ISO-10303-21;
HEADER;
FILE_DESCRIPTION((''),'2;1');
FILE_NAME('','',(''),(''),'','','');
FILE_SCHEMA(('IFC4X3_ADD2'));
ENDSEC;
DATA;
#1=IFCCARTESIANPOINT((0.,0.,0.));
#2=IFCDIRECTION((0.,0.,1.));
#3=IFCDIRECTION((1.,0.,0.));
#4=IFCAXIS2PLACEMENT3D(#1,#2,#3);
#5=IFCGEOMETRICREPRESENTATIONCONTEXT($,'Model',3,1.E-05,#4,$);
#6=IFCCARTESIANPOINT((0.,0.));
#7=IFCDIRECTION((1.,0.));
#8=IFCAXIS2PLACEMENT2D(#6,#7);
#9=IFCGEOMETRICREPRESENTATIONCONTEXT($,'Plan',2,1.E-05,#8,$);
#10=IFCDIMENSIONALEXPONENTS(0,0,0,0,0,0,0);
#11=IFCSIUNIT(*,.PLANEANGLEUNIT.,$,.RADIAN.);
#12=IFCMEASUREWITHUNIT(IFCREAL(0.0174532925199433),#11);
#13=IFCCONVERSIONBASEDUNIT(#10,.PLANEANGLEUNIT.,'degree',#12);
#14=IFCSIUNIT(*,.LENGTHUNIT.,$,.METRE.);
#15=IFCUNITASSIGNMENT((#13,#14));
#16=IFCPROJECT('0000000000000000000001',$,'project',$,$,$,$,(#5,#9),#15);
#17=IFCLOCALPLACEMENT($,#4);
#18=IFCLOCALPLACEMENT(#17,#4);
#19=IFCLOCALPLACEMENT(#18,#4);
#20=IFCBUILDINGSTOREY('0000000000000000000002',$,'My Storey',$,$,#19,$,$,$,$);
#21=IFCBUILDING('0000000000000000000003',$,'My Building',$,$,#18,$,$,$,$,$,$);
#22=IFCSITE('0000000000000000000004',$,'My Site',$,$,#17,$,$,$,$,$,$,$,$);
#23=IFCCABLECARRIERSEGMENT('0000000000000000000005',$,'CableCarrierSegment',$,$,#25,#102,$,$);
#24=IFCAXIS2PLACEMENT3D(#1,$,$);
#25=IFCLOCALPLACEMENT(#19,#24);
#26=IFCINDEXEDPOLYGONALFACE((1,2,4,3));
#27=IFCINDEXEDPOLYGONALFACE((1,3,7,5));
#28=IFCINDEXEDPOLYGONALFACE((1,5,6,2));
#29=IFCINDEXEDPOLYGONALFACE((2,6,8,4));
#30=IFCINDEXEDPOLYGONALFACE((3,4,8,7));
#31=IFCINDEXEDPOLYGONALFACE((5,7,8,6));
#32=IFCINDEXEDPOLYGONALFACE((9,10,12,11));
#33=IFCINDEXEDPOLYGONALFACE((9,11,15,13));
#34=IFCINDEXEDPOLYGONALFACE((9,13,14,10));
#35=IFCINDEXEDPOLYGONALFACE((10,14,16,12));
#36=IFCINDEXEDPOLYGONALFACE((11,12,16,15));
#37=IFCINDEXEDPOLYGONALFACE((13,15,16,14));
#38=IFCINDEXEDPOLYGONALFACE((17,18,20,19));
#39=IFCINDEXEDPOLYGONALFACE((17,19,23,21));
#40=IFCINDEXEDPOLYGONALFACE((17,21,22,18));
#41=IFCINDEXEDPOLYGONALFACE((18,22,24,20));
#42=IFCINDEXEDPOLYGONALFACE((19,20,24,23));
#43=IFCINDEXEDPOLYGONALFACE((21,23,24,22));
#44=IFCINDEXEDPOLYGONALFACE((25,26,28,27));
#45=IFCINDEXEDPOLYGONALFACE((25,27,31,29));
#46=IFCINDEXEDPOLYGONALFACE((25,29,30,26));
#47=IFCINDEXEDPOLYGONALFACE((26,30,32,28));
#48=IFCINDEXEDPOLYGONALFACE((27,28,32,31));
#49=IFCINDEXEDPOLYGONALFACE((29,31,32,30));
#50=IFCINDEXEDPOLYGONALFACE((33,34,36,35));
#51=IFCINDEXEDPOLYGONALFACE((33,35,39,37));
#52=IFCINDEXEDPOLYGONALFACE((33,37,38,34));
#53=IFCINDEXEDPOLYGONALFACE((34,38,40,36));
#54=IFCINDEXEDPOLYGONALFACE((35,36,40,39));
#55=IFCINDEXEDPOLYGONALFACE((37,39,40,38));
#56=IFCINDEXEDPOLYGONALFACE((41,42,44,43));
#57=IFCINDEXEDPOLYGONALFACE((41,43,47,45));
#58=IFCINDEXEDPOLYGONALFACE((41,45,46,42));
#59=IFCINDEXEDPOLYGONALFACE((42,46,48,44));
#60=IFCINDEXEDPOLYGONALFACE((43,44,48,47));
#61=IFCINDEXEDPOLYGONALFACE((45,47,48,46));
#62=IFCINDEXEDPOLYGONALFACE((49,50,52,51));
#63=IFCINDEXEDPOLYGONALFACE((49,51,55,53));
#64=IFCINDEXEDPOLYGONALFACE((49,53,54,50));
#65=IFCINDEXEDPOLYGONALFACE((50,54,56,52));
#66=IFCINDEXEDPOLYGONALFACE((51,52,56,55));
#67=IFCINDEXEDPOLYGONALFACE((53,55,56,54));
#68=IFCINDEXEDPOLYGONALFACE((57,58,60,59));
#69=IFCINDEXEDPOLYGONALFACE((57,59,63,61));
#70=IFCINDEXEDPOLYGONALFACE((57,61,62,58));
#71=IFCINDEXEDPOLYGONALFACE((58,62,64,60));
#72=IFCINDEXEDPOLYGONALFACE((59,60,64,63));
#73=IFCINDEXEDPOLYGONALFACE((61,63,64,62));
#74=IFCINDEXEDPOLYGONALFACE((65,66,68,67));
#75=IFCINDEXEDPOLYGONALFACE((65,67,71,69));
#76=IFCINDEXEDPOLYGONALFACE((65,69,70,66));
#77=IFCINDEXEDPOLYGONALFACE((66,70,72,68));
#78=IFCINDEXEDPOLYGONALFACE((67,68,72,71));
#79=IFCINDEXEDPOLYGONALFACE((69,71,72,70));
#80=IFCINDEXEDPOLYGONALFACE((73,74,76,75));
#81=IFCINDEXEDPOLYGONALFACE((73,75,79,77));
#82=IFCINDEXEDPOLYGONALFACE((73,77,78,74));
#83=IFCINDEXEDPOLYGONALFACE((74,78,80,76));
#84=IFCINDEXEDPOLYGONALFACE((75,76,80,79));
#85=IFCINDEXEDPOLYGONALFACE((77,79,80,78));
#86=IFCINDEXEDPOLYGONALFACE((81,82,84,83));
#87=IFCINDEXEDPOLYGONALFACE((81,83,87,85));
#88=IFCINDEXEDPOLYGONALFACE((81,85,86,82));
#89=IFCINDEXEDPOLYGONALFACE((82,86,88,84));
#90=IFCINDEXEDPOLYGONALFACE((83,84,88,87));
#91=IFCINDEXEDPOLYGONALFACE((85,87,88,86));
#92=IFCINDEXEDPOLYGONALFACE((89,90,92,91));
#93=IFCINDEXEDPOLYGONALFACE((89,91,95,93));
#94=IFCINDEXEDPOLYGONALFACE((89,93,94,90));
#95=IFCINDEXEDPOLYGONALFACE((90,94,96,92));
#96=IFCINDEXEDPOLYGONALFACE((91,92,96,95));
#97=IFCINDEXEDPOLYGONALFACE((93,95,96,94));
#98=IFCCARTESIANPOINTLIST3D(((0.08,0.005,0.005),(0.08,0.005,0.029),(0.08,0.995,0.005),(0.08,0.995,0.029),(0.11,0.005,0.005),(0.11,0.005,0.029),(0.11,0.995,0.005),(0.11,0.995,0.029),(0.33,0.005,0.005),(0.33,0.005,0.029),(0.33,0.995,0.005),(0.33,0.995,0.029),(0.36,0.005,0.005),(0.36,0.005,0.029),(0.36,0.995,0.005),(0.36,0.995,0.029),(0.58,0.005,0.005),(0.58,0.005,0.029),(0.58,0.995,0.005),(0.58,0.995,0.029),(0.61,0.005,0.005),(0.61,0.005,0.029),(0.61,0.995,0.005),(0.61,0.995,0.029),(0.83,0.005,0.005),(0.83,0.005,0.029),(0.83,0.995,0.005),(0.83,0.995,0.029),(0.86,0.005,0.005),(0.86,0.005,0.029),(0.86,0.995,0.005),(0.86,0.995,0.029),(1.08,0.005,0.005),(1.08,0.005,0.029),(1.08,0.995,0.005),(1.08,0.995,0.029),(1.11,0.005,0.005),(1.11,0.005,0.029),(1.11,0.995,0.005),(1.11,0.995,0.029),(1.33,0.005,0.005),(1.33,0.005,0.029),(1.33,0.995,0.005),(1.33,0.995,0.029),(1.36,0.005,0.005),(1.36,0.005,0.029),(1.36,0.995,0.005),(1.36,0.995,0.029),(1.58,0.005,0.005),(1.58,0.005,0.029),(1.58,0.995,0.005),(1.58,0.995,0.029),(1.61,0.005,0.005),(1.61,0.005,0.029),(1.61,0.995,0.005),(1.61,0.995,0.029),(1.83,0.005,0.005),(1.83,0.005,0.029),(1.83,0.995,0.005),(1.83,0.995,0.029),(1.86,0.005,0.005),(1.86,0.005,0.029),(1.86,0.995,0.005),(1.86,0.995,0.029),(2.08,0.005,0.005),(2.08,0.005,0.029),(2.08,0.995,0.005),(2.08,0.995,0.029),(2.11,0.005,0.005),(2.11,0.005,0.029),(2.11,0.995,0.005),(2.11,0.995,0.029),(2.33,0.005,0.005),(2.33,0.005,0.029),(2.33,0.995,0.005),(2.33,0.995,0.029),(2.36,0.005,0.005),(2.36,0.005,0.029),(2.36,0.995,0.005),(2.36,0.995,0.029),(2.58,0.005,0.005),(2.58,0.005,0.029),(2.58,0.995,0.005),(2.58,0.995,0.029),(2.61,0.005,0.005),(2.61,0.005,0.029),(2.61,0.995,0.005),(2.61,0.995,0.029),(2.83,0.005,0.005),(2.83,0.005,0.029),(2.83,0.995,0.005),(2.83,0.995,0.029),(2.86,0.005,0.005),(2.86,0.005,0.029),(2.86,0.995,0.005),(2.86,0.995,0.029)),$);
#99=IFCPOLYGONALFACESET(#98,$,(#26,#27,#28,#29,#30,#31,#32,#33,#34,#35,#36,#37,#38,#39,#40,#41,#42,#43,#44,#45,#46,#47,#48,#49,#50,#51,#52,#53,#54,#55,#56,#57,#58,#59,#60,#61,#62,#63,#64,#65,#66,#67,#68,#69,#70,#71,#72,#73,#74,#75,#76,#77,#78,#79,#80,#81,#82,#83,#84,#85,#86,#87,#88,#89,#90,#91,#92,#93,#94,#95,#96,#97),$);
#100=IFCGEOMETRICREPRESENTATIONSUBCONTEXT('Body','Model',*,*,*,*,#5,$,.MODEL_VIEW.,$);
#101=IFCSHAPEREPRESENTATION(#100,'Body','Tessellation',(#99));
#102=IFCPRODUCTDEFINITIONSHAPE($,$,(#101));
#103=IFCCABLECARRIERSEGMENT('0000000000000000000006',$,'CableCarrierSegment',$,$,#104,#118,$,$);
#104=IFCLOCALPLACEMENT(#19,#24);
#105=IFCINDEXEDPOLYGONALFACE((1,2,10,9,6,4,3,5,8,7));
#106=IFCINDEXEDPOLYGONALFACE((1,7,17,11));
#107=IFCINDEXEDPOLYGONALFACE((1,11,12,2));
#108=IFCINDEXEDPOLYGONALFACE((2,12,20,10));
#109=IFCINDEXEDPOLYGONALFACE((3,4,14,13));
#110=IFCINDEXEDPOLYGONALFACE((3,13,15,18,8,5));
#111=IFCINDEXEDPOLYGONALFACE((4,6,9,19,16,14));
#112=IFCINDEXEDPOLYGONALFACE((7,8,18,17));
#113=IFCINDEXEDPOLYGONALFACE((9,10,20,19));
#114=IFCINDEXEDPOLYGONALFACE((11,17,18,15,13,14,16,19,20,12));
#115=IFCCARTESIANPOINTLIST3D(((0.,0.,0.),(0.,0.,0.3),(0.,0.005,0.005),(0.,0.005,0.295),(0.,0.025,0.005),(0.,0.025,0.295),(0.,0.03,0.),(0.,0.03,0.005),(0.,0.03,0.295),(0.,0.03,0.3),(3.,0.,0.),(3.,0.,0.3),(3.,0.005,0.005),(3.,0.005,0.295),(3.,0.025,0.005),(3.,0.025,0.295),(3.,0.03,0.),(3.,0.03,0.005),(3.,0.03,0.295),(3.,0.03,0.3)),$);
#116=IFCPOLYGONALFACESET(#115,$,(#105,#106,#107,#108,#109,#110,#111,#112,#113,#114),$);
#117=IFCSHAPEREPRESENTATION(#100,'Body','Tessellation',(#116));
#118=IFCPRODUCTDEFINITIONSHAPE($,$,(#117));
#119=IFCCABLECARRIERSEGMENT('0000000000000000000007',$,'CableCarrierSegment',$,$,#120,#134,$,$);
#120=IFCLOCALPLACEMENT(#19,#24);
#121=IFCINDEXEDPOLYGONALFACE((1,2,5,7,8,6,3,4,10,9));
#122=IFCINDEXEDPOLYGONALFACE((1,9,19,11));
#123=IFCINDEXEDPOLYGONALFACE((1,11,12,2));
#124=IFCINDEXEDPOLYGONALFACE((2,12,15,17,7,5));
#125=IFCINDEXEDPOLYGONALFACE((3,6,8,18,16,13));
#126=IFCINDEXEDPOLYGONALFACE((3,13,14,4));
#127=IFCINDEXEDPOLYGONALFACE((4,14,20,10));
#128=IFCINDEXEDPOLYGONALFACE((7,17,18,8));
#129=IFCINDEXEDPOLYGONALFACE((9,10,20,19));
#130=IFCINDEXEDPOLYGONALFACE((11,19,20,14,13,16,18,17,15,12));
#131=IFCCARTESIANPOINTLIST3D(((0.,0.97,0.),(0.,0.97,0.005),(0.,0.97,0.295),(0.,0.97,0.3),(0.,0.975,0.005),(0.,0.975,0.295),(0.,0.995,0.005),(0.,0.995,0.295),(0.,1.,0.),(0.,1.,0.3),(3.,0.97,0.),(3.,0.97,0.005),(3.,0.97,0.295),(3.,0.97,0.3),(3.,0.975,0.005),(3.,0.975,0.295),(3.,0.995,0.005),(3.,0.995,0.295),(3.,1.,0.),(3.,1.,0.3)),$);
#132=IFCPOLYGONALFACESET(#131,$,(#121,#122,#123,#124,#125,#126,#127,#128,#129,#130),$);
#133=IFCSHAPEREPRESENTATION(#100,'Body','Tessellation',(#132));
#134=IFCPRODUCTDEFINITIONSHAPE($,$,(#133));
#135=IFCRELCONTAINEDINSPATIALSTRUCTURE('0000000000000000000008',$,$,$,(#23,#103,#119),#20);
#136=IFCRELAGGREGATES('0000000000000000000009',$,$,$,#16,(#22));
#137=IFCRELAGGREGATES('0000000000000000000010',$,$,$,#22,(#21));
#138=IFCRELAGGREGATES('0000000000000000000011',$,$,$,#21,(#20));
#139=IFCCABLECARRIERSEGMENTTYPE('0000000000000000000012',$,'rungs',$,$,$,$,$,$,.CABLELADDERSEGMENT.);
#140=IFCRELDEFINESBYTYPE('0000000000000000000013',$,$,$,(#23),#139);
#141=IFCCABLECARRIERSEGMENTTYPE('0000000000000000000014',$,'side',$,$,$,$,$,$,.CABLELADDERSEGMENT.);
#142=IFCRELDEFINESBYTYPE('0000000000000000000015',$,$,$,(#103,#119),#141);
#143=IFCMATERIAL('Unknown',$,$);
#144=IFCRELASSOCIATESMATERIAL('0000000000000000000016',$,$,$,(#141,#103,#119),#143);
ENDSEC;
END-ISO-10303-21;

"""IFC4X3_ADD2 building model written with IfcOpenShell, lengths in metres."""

from ifc_helpers import new_model, entity, si_unit, converted_unit, frame, origin_with_axes, origin_2d_with_axis, place, context, subcontext, project, spatial, indexed_curve, c_section, outline, composite_profile, extrude, source, transform, mapped, material, material_profile, profile_set, profile_usage, type_object, type_shapes, element, save


model = new_model("IFC4X3_ADD2")

# Units and contexts
model_context = context("Model", 3, precision=1e-05, world=origin_with_axes())
plan_context = context("Plan", 2, precision=1e-05, world=origin_2d_with_axis())
body_context = subcontext(model_context, "Body", "Model", "MODEL_VIEW")
ifc_project = project(units=[converted_unit("PLANEANGLEUNIT", "degree", entity("IfcReal", 0.0174532925199433), si_unit("PLANEANGLEUNIT", "RADIAN"), dimensions=[0, 0, 0, 0, 0, 0, 0]), si_unit("LENGTHUNIT", "METRE")], contexts=[model_context, plan_context])

# Site, building, storey
site_placement = place(None, origin_with_axes())
site = spatial("IfcSite", under=ifc_project, at=site_placement, Name="My Site")
building_placement = place(site_placement, origin_with_axes())
building = spatial("IfcBuilding", under=site, at=building_placement, Name="My Building")
storey_placement = place(building_placement, origin_with_axes())
storey = spatial("IfcBuildingStorey", under=building, at=storey_placement, Name="My Storey")

# Cable carrier segments
cable_carrier_segment_type_1 = type_object("IfcCableCarrierSegmentType", Name="rungs", PredefinedType="CABLELADDERSEGMENT")
shared_shape = source(origin_with_axes(), body_context, "Body", "SweptSolid", [
    extrude(composite_profile([outline(indexed_curve([(-2.75, 0.0), (-2.72, 0.0), (-2.72, 0.024), (-2.75, 0.024), (-2.75, 0.0)])), outline(indexed_curve([(-2.5, 0.0), (-2.47, 0.0), (-2.47, 0.024), (-2.5, 0.024), (-2.5, 0.0)])), outline(indexed_curve([(-2.25, 0.0), (-2.22, 0.0), (-2.22, 0.024), (-2.25, 0.024), (-2.25, 0.0)])), outline(indexed_curve([(-2.0, 0.0), (-1.97, 0.0), (-1.97, 0.024), (-2.0, 0.024), (-2.0, 0.0)])), outline(indexed_curve([(-1.75, 0.0), (-1.72, 0.0), (-1.72, 0.024), (-1.75, 0.024), (-1.75, 0.0)])), outline(indexed_curve([(-1.5, 0.0), (-1.47, 0.0), (-1.47, 0.024), (-1.5, 0.024), (-1.5, 0.0)])), outline(indexed_curve([(-1.25, 0.0), (-1.22, 0.0), (-1.22, 0.024), (-1.25, 0.024), (-1.25, 0.0)])), outline(indexed_curve([(-1.0, 0.0), (-0.97, 0.0), (-0.97, 0.024), (-1.0, 0.024), (-1.0, 0.0)])), outline(indexed_curve([(-0.75, 0.0), (-0.72, 0.0), (-0.72, 0.024), (-0.75, 0.024), (-0.75, 0.0)])), outline(indexed_curve([(-0.5, 0.0), (-0.47, 0.0), (-0.47, 0.024), (-0.5, 0.024), (-0.5, 0.0)])), outline(indexed_curve([(-0.25, 0.0), (-0.22, 0.0), (-0.22, 0.024), (-0.25, 0.024), (-0.25, 0.0)])), outline(indexed_curve([(0.0, 0.0), (0.03, 0.0), (0.03, 0.024), (0.0, 0.024), (0.0, 0.0)]))]), frame((0.11, 0.005, 0.005), z_axis=(0.0, 1.0, 0.0), x_axis=(-1.0, 0.0, 0.0)), (0.0, 0.0, 1.0), 0.99),
])
type_shapes(cable_carrier_segment_type_1, [shared_shape])
cable_carrier_segment_1_placement = place(storey_placement, origin_with_axes())
element("IfcCableCarrierSegment", 1, at=cable_carrier_segment_1_placement, inside=storey, type_object=cable_carrier_segment_type_1, Name="CableCarrierSegment", context=body_context, shape_type="MappedRepresentation", body=[
    mapped(shared_shape, transform((0.0, 0.0, 0.0), x_axis=(1.0, 0.0, 0.0), y_axis=(0.0, 1.0, 0.0), z_axis=(0.0, 0.0, 1.0), scale=1.0)),
])
ifc_material = material(Name="Unknown")
ifc_material_profile = material_profile(ifc_material, c_section(Depth=0.3, Width=0.03, WallThickness=0.005, Girth=0.005))
ifc_profile_set = profile_set([ifc_material_profile])
ifc_profile_usage_1 = profile_usage(ifc_profile_set, cardinal=3)
cable_carrier_segment_type_2 = type_object("IfcCableCarrierSegmentType", Name="side", PredefinedType="CABLELADDERSEGMENT", material=ifc_profile_set)
cable_carrier_segment_2_placement = place(storey_placement, frame((0.0, 0.0, 0.0), z_axis=(1.0, 0.0, 0.0), x_axis=(0.0, 1.0, 0.0)))
element("IfcCableCarrierSegment", 2, at=cable_carrier_segment_2_placement, inside=storey, type_object=cable_carrier_segment_type_2, material=ifc_profile_usage_1, Name="CableCarrierSegment", context=body_context, shape_type="SweptSolid", body=[
    extrude(c_section(Depth=0.3, Width=0.03, WallThickness=0.005, Girth=0.005), frame((0.015, 0.15, 0.0), z_axis=(0.0, 0.0, 1.0), x_axis=(1.0, 0.0, 0.0)), (0.0, 0.0, 1.0), 3.0),
])
ifc_profile_usage_2 = profile_usage(ifc_profile_set, cardinal=3)
cable_carrier_segment_3_placement = place(storey_placement, frame((3.0, 1.0, 0.0), z_axis=(-1.0, 0.0, 0.0), x_axis=(0.0, -1.0, 0.0)))
element("IfcCableCarrierSegment", 3, at=cable_carrier_segment_3_placement, inside=storey, type_object=cable_carrier_segment_type_2, material=ifc_profile_usage_2, Name="CableCarrierSegment", context=body_context, shape_type="SweptSolid", body=[
    extrude(c_section(Depth=0.3, Width=0.03, WallThickness=0.005, Girth=0.005), frame((0.015, 0.15, 0.0), z_axis=(0.0, 0.0, 1.0), x_axis=(1.0, 0.0, 0.0)), (0.0, 0.0, 1.0), 3.0),
])

save(model, "model.ifc")
